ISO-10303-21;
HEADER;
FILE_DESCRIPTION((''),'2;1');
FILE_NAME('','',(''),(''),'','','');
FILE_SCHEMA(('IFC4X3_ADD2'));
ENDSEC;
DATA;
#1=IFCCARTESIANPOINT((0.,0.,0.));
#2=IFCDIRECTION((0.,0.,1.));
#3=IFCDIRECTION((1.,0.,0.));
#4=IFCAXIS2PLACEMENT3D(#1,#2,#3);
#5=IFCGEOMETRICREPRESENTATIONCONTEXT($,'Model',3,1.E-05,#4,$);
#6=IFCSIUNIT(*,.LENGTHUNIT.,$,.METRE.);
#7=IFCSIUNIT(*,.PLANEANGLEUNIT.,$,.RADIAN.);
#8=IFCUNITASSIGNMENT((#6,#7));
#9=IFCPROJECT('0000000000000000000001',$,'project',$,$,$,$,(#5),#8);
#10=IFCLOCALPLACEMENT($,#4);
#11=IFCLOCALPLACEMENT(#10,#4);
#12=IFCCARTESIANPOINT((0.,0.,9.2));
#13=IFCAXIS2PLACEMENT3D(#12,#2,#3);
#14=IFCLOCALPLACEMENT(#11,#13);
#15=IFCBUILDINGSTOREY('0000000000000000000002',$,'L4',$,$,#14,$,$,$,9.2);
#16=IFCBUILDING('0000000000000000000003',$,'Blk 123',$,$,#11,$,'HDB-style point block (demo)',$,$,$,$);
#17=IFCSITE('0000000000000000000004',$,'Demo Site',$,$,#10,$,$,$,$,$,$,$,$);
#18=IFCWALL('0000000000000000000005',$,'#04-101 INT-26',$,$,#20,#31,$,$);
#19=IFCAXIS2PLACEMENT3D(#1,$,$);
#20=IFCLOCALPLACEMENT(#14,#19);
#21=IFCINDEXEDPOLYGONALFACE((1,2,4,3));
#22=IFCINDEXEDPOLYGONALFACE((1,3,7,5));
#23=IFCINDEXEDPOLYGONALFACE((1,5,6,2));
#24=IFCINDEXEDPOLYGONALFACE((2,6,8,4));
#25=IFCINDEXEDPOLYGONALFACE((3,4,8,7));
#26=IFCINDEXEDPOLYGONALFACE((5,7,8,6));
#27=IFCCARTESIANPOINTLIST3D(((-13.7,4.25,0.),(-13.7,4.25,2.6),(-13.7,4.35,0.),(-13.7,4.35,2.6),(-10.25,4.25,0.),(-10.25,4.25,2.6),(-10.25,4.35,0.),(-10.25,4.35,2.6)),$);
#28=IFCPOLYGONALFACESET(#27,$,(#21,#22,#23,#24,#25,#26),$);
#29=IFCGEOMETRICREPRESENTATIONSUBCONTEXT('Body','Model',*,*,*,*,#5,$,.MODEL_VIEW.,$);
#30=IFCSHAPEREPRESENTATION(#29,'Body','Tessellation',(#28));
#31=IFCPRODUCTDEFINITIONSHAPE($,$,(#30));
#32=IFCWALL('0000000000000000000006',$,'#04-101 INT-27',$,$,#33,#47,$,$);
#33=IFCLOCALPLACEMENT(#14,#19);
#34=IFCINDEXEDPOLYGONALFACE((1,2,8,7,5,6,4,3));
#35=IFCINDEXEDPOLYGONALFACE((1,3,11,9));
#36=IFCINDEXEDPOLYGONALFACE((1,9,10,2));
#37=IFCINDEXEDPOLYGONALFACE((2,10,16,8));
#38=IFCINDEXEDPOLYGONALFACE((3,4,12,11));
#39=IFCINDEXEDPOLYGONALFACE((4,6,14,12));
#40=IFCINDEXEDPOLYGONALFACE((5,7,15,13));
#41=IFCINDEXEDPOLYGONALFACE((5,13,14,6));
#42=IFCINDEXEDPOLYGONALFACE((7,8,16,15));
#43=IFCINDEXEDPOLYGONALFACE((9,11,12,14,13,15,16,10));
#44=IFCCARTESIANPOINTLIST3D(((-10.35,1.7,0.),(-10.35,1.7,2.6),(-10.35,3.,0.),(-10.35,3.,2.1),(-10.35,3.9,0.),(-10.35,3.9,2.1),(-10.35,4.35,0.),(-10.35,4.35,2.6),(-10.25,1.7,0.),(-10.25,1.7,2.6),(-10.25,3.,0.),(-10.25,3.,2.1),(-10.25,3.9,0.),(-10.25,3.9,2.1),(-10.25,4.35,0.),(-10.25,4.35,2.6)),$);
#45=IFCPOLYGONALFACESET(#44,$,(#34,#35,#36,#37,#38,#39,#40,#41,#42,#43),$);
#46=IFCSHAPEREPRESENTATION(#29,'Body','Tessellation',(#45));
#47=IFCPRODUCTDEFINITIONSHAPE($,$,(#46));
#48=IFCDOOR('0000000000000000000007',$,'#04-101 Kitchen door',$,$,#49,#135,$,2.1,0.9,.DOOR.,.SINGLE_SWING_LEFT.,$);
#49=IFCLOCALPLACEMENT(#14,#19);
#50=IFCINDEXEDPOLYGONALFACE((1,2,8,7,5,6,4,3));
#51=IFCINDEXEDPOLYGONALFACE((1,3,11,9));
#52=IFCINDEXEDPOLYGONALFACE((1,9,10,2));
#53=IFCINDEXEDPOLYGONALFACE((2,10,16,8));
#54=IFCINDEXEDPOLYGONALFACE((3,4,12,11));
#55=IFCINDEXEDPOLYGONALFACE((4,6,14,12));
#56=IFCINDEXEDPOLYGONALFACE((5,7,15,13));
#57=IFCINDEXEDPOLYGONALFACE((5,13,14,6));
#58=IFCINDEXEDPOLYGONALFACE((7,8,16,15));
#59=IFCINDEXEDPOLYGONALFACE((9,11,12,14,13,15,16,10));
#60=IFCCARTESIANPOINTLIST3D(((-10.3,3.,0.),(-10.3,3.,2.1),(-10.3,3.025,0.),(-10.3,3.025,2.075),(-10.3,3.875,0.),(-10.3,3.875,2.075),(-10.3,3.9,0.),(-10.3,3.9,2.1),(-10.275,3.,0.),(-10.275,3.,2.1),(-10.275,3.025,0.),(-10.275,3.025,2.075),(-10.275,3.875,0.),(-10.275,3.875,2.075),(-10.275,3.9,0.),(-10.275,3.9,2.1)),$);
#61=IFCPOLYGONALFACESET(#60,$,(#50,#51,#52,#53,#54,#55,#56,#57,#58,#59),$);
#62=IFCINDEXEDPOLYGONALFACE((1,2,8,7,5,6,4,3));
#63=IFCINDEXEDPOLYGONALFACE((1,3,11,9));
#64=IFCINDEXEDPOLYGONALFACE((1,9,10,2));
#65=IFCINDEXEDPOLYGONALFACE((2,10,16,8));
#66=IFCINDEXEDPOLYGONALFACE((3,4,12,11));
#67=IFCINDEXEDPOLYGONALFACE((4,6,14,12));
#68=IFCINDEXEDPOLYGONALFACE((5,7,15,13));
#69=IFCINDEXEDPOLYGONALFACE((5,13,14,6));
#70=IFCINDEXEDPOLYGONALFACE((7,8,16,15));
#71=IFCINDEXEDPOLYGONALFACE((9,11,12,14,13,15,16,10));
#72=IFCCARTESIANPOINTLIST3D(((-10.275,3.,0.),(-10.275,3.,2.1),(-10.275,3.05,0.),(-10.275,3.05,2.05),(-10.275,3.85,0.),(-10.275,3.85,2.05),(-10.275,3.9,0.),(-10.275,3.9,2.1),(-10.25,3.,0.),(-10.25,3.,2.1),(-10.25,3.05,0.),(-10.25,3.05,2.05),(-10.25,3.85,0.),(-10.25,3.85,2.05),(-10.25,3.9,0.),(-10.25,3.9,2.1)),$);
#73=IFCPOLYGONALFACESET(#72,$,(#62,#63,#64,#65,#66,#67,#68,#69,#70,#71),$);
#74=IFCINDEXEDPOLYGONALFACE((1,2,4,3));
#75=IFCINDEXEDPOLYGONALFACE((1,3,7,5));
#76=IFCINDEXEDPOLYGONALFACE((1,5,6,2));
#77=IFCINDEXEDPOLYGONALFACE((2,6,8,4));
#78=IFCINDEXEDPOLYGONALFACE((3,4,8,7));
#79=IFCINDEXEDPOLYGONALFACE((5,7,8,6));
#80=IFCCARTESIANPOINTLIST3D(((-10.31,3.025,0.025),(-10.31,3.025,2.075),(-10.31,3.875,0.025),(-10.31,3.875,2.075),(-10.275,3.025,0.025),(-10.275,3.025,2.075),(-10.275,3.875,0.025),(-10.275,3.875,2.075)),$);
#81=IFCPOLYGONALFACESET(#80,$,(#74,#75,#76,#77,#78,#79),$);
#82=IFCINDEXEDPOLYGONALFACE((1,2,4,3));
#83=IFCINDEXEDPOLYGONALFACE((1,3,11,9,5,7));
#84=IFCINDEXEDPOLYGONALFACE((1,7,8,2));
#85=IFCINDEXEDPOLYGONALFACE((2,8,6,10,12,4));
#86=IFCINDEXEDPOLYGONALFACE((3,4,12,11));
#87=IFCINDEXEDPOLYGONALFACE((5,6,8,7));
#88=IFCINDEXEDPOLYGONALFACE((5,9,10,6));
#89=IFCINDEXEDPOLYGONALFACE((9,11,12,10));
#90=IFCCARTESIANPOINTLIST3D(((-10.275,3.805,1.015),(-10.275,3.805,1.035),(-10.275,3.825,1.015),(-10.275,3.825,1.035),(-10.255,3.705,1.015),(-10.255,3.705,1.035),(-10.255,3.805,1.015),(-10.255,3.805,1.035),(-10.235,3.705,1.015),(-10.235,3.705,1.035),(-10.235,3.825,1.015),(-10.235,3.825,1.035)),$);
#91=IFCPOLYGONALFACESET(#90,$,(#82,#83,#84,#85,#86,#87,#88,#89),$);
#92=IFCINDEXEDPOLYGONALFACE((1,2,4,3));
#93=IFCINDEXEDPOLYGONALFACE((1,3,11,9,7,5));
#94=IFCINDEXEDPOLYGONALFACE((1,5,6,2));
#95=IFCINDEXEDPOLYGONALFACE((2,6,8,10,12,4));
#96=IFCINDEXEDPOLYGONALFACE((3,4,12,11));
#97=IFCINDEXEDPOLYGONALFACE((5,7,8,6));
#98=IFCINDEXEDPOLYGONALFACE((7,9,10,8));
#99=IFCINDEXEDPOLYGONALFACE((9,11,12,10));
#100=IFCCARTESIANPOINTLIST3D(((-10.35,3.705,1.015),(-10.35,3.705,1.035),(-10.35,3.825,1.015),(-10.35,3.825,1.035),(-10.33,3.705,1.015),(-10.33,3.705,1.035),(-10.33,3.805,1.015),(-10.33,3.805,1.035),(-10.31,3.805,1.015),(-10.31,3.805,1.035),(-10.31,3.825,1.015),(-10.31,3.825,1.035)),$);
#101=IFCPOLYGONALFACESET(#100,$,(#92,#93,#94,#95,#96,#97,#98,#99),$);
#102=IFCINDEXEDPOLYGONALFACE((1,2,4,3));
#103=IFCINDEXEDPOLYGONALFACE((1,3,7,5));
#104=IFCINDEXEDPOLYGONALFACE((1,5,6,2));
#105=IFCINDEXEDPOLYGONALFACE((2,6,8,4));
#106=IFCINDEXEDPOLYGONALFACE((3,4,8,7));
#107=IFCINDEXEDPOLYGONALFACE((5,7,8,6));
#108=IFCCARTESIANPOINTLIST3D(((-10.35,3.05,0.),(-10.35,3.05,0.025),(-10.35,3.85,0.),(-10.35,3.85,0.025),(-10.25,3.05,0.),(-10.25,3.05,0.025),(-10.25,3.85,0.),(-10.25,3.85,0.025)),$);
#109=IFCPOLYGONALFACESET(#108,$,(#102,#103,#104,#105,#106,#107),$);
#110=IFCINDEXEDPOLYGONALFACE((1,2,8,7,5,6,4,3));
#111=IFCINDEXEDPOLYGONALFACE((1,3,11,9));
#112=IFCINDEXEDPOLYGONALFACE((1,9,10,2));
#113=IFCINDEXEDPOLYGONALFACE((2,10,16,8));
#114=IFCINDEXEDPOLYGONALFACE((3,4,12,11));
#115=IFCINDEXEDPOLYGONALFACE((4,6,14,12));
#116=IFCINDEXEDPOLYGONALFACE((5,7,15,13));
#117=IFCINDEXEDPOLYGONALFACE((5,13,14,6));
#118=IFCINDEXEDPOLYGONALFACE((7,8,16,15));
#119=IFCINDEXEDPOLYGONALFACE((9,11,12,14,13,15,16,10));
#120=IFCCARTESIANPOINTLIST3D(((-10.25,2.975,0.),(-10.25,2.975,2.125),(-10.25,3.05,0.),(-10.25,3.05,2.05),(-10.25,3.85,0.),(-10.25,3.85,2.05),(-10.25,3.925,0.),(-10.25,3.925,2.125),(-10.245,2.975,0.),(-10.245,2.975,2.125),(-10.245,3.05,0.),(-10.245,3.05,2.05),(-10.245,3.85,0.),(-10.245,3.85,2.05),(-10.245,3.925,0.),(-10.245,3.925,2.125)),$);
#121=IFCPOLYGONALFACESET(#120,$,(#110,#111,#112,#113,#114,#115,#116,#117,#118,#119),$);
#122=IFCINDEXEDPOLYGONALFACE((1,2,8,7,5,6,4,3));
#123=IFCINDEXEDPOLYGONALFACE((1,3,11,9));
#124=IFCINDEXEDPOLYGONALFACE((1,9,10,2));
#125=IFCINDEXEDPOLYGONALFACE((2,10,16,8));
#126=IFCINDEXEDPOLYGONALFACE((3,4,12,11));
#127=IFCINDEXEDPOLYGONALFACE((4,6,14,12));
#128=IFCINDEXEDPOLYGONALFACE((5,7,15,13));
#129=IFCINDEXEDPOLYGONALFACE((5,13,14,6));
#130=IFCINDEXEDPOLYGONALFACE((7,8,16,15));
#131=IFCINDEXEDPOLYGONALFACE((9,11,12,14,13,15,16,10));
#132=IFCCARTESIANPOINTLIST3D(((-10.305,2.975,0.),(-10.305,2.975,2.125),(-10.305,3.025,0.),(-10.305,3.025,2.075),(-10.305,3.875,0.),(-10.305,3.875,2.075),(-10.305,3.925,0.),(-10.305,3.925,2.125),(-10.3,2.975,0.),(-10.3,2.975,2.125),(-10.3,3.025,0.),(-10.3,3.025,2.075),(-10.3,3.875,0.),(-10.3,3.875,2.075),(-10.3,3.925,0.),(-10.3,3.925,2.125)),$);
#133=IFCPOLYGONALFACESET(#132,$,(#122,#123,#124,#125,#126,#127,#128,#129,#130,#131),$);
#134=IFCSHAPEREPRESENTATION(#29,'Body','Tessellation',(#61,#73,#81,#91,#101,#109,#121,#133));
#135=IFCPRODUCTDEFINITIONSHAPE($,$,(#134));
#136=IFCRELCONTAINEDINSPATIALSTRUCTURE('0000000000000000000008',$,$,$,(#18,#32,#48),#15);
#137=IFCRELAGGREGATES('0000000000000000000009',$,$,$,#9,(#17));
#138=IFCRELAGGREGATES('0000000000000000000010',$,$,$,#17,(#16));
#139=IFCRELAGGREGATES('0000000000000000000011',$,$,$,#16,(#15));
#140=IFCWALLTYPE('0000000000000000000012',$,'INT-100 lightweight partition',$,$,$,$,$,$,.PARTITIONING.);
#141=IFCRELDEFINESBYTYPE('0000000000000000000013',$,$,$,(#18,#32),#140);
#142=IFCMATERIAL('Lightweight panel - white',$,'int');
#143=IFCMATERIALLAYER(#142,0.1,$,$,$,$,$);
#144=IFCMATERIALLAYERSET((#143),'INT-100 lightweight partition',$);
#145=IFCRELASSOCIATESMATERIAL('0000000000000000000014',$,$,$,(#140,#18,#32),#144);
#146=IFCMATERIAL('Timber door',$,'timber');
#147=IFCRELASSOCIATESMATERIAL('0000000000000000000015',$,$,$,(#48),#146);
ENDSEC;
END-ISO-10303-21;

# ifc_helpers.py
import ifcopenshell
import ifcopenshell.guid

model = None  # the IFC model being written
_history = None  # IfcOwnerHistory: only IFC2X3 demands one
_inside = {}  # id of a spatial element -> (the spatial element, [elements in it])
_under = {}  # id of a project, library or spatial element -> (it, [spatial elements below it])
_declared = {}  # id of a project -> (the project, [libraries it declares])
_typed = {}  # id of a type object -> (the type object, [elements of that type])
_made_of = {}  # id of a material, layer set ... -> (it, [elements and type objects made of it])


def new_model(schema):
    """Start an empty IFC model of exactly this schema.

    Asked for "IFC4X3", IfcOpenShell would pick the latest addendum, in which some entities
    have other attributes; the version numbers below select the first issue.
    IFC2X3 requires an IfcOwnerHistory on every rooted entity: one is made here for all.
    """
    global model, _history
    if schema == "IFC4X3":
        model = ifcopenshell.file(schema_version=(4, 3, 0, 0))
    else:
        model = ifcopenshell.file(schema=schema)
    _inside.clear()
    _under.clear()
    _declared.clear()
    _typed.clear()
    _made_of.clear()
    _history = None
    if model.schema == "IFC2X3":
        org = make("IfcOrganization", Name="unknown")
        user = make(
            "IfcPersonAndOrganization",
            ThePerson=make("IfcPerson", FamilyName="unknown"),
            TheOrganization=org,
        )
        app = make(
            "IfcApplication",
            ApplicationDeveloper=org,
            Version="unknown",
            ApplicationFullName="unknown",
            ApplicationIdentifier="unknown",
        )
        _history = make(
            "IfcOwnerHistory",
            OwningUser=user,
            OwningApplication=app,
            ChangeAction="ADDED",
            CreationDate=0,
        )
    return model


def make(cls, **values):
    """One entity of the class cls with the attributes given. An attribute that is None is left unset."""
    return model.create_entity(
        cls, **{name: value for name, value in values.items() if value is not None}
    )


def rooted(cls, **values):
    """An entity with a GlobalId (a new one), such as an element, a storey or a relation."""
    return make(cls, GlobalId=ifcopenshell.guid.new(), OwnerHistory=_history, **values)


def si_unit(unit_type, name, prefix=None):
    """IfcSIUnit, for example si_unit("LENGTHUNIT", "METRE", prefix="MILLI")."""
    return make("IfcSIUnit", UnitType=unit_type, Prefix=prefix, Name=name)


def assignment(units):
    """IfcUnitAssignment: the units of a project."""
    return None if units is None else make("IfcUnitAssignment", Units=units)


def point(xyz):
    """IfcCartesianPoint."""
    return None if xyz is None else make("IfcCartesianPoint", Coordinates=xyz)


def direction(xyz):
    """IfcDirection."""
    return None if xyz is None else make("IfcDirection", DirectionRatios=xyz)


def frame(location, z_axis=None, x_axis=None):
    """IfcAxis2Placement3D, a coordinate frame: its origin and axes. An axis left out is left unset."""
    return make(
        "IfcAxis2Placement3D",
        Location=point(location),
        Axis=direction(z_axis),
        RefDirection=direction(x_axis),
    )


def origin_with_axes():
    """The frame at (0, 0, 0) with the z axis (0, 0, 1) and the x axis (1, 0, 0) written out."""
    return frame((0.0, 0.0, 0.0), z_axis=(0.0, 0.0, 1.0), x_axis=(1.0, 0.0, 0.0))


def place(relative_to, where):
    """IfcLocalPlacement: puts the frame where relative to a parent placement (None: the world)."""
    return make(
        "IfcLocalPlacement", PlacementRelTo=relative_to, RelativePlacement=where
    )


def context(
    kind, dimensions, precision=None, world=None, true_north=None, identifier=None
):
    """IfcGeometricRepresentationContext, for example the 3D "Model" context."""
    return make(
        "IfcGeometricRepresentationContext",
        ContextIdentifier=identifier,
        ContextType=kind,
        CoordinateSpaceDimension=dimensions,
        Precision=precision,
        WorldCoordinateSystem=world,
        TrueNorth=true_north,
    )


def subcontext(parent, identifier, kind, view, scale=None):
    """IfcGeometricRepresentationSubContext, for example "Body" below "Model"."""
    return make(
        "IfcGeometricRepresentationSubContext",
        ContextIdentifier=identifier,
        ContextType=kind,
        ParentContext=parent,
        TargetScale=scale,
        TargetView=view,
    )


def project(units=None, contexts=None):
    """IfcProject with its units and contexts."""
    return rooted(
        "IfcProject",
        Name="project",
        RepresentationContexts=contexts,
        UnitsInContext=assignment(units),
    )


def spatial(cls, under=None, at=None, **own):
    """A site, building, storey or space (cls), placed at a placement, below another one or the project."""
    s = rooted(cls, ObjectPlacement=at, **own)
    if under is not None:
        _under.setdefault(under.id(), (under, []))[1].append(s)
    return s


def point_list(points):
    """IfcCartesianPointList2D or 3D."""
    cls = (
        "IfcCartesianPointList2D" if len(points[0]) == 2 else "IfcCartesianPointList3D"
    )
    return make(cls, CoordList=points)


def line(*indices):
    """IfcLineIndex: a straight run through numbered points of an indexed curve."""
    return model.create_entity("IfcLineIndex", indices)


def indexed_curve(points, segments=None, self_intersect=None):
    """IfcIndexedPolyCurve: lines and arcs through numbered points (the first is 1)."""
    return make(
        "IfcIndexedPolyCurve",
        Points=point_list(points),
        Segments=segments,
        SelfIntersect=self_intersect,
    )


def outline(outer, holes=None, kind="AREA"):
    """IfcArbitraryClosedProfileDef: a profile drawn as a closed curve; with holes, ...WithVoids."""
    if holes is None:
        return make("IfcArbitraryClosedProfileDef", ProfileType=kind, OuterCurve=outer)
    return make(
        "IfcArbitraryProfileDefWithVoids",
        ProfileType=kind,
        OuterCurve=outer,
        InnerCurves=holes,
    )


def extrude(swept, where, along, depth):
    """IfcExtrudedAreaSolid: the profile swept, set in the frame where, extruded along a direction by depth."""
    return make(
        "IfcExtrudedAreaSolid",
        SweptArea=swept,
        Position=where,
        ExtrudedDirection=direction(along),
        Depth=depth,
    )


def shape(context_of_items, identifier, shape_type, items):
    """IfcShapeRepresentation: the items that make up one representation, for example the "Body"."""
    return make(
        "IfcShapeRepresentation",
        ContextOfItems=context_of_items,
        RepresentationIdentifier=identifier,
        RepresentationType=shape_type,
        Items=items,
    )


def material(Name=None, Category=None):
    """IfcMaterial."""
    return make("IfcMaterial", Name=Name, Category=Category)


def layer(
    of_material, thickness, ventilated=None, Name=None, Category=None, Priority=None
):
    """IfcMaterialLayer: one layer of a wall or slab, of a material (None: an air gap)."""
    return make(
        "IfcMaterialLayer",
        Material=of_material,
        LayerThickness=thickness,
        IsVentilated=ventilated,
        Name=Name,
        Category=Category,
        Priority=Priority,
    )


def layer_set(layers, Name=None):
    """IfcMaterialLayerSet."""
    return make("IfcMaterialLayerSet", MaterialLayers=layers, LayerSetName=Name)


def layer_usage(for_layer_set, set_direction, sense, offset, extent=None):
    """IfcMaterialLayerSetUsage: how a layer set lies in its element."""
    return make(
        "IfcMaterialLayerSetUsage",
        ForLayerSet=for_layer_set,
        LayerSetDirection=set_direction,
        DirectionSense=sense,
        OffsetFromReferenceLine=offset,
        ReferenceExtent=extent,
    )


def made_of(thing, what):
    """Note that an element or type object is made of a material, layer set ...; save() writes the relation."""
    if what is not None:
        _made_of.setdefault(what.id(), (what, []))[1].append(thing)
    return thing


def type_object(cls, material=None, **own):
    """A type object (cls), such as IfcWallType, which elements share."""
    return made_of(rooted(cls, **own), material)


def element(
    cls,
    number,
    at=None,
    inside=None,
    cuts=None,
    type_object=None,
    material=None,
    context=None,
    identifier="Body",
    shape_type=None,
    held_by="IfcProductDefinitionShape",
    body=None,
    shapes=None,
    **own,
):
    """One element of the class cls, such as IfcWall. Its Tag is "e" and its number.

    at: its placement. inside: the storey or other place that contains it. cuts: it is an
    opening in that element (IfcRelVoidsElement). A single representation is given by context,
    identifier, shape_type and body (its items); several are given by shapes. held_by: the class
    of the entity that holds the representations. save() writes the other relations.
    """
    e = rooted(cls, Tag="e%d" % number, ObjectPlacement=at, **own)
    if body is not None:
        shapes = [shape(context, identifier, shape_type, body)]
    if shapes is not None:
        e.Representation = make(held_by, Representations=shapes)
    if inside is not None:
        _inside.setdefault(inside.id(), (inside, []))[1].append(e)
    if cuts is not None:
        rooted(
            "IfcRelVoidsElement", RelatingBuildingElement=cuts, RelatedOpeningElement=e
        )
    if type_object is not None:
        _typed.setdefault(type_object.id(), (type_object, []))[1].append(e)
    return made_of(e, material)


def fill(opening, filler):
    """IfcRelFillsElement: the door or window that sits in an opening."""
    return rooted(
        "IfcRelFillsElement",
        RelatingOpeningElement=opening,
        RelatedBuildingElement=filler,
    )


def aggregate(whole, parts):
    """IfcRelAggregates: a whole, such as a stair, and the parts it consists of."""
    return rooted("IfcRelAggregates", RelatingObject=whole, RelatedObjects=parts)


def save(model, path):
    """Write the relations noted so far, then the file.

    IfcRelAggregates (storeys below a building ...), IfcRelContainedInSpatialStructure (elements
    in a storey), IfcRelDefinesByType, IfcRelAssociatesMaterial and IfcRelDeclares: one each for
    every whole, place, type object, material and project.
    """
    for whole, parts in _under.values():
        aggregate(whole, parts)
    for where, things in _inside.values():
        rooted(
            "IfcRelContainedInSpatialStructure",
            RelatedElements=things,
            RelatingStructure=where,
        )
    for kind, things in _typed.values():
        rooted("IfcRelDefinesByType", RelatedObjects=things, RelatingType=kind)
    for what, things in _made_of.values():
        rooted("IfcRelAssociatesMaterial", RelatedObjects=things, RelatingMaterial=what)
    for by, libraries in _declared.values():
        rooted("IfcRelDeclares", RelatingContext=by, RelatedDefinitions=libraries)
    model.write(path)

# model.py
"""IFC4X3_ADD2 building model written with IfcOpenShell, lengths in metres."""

from ifc_helpers import new_model, si_unit, frame, origin_with_axes, place, context, subcontext, project, spatial, line, indexed_curve, outline, extrude, material, layer, layer_set, layer_usage, type_object, element, fill, save


model = new_model("IFC4X3_ADD2")

# Units and contexts
model_context = context("Model", 3, precision=1e-05, world=origin_with_axes())
body_context = subcontext(model_context, "Body", "Model", "MODEL_VIEW")
ifc_project = project(units=[si_unit("LENGTHUNIT", "METRE"), si_unit("PLANEANGLEUNIT", "RADIAN")], contexts=[model_context])

# Site, building, storey
site_placement = place(None, origin_with_axes())
site = spatial("IfcSite", under=ifc_project, at=site_placement, Name="Demo Site")
building_placement = place(site_placement, origin_with_axes())
building = spatial("IfcBuilding", under=site, at=building_placement, Name="Blk 123", LongName="HDB-style point block (demo)")
storey_placement = place(building_placement, frame((0.0, 0.0, 9.2), z_axis=(0.0, 0.0, 1.0), x_axis=(1.0, 0.0, 0.0)))
storey = spatial("IfcBuildingStorey", under=building, at=storey_placement, Name="L4", Elevation=9.2)

# Shared definitions
ifc_material_1 = material(Name="Timber door", Category="timber")

# Wall
ifc_material_2 = material(Name="Lightweight panel - white", Category="int")
ifc_layer_1 = layer(ifc_material_2, 0.1)
ifc_layer_set_1 = layer_set([ifc_layer_1], Name="INT-100 lightweight partition")
ifc_layer_usage_1 = layer_usage(ifc_layer_set_1, "AXIS2", "POSITIVE", -0.05)
wall_type_1 = type_object("IfcWallType", Name="INT-100 lightweight partition", PredefinedType="PARTITIONING", material=ifc_layer_set_1)
wall_1_placement = place(storey_placement, frame((-10.25, 4.3, 0.0), z_axis=(0.0, 0.0, 1.0), x_axis=(-1.0, 0.0, 0.0)))
element("IfcWall", 1, at=wall_1_placement, inside=storey, type_object=wall_type_1, material=ifc_layer_usage_1, Name="#04-101 INT-26", context=body_context, shape_type="SweptSolid", body=[
    extrude(outline(indexed_curve([(0.0, 0.0), (0.0, 0.1), (3.45, 0.1), (3.45, 0.0), (0.0, 0.0)], self_intersect=False)), frame((0.0, -0.05, 0.0), z_axis=(0.0, 0.0, 1.0), x_axis=(1.0, 0.0, 0.0)), (0.0, 0.0, 1.0), 2.6),
])

# Wall, opening, door
wall_2_placement = place(storey_placement, frame((-10.3, 1.7, 0.0), z_axis=(0.0, 0.0, 1.0), x_axis=(0.0, 1.0, 0.0)))
wall_2 = element("IfcWall", 2, at=wall_2_placement, inside=storey, type_object=wall_type_1, material=ifc_layer_usage_1, Name="#04-101 INT-27", context=body_context, shape_type="SweptSolid", body=[
    extrude(outline(indexed_curve([(0.0, 0.0), (0.0, 0.1), (2.65, 0.1), (2.65, 0.0), (0.0, 0.0)], self_intersect=False)), frame((0.0, -0.05, 0.0), z_axis=(0.0, 0.0, 1.0), x_axis=(1.0, 0.0, 0.0)), (0.0, 0.0, 1.0), 2.6),
])
opening_1_placement = place(wall_2_placement, frame((1.3, -0.15, 0.0), z_axis=(0.0, 0.0, 1.0), x_axis=(1.0, 0.0, 0.0)))
opening_1 = element("IfcOpeningElement", 3, at=opening_1_placement, cuts=wall_2, context=body_context, shape_type="SweptSolid", body=[
    extrude(outline(indexed_curve([(0.0, 0.0), (0.0, 0.3), (0.9, 0.3), (0.9, 0.0), (0.0, 0.0)], self_intersect=False)), origin_with_axes(), (0.0, 0.0, 1.0), 2.1),
])
door_1_placement = place(opening_1_placement, frame((0.0, 0.1, 0.0), z_axis=(0.0, 0.0, 1.0), x_axis=(1.0, 0.0, 0.0)))
door_1 = element("IfcDoor", 4, at=door_1_placement, inside=storey, material=ifc_material_1, Name="#04-101 Kitchen door", OperationType="SINGLE_SWING_LEFT", OverallHeight=2.1, OverallWidth=0.9, PredefinedType="DOOR", context=body_context, shape_type="SweptSolid", body=[
    extrude(outline(indexed_curve([(0.0, 0.0), (0.0, 2.1), (0.9, 2.1), (0.9, 0.0), (0.875, 0.0), (0.875, 2.075), (0.025, 2.075), (0.025, 0.0)], segments=[line(1, 2, 3, 4, 5, 6, 7, 8, 1)])), frame((0.0, 0.025, 0.0), z_axis=(0.0, -1.0, 0.0), x_axis=(1.0, 0.0, 0.0)), (0.0, 0.0, -1.0), 0.025),
    extrude(outline(indexed_curve([(0.0, 0.0), (0.0, 2.1), (0.9, 2.1), (0.9, 0.0), (0.85, 0.0), (0.85, 2.05), (0.05, 2.05), (0.05, 0.0)], segments=[line(1, 2, 3, 4, 5, 6, 7, 8, 1)])), frame((0.0, 0.0, 0.0), z_axis=(0.0, -1.0, 0.0), x_axis=(1.0, 0.0, 0.0)), (0.0, 0.0, -1.0), 0.025),
    extrude(outline(indexed_curve([(0.0, 0.0), (0.85, 0.0), (0.85, 0.035), (0.0, 0.035)], segments=[line(1, 2, 3, 4, 1)])), frame((0.025, 0.025, 0.025), z_axis=(0.0, 0.0, 1.0), x_axis=(1.0, 0.0, 0.0)), (0.0, 0.0, 1.0), 2.05),
    extrude(outline(indexed_curve([(0.0, 0.0), (0.0, -0.04), (-0.12, -0.04), (-0.12, -0.02), (-0.02, -0.02), (-0.02, 0.0)], segments=[line(1, 2, 3, 4, 5, 6, 1)])), frame((0.825, 0.025, 1.015), z_axis=(0.0, 0.0, 1.0), x_axis=(1.0, 0.0, 0.0)), (0.0, 0.0, 1.0), 0.02),
    extrude(outline(indexed_curve([(0.0, 0.0), (0.0, 0.04), (-0.12, 0.04), (-0.12, 0.02), (-0.02, 0.02), (-0.02, 0.0)], segments=[line(1, 2, 3, 4, 5, 6, 1)])), frame((0.825, 0.06, 1.015), z_axis=(0.0, 0.0, 1.0), x_axis=(1.0, 0.0, 0.0)), (0.0, 0.0, 1.0), 0.02),
    extrude(outline(indexed_curve([(0.0, 0.0), (0.8, 0.0), (0.8, 0.1), (0.0, 0.1)], segments=[line(1, 2, 3, 4, 1)])), frame((0.05, 0.0, 0.0), z_axis=(0.0, 0.0, 1.0), x_axis=(1.0, 0.0, 0.0)), (0.0, 0.0, 1.0), 0.025),
    extrude(outline(indexed_curve([(0.0, 0.0), (0.0, 2.125), (0.95, 2.125), (0.95, 0.0), (0.875, 0.0), (0.875, 2.05), (0.075, 2.05), (0.075, 0.0)], segments=[line(1, 2, 3, 4, 5, 6, 7, 8, 1)])), frame((-0.025, -0.005, 0.0), z_axis=(0.0, -1.0, 0.0), x_axis=(1.0, 0.0, 0.0)), (0.0, 0.0, -1.0), 0.005),
    extrude(outline(indexed_curve([(0.0, 0.0), (0.0, 2.125), (0.95, 2.125), (0.95, 0.0), (0.9, 0.0), (0.9, 2.075), (0.05, 2.075), (0.05, 0.0)], segments=[line(1, 2, 3, 4, 5, 6, 7, 8, 1)])), frame((-0.025, 0.05, 0.0), z_axis=(0.0, -1.0, 0.0), x_axis=(1.0, 0.0, 0.0)), (0.0, 0.0, -1.0), 0.005),
])
fill(opening_1, door_1)

save(model, "model.ifc")
